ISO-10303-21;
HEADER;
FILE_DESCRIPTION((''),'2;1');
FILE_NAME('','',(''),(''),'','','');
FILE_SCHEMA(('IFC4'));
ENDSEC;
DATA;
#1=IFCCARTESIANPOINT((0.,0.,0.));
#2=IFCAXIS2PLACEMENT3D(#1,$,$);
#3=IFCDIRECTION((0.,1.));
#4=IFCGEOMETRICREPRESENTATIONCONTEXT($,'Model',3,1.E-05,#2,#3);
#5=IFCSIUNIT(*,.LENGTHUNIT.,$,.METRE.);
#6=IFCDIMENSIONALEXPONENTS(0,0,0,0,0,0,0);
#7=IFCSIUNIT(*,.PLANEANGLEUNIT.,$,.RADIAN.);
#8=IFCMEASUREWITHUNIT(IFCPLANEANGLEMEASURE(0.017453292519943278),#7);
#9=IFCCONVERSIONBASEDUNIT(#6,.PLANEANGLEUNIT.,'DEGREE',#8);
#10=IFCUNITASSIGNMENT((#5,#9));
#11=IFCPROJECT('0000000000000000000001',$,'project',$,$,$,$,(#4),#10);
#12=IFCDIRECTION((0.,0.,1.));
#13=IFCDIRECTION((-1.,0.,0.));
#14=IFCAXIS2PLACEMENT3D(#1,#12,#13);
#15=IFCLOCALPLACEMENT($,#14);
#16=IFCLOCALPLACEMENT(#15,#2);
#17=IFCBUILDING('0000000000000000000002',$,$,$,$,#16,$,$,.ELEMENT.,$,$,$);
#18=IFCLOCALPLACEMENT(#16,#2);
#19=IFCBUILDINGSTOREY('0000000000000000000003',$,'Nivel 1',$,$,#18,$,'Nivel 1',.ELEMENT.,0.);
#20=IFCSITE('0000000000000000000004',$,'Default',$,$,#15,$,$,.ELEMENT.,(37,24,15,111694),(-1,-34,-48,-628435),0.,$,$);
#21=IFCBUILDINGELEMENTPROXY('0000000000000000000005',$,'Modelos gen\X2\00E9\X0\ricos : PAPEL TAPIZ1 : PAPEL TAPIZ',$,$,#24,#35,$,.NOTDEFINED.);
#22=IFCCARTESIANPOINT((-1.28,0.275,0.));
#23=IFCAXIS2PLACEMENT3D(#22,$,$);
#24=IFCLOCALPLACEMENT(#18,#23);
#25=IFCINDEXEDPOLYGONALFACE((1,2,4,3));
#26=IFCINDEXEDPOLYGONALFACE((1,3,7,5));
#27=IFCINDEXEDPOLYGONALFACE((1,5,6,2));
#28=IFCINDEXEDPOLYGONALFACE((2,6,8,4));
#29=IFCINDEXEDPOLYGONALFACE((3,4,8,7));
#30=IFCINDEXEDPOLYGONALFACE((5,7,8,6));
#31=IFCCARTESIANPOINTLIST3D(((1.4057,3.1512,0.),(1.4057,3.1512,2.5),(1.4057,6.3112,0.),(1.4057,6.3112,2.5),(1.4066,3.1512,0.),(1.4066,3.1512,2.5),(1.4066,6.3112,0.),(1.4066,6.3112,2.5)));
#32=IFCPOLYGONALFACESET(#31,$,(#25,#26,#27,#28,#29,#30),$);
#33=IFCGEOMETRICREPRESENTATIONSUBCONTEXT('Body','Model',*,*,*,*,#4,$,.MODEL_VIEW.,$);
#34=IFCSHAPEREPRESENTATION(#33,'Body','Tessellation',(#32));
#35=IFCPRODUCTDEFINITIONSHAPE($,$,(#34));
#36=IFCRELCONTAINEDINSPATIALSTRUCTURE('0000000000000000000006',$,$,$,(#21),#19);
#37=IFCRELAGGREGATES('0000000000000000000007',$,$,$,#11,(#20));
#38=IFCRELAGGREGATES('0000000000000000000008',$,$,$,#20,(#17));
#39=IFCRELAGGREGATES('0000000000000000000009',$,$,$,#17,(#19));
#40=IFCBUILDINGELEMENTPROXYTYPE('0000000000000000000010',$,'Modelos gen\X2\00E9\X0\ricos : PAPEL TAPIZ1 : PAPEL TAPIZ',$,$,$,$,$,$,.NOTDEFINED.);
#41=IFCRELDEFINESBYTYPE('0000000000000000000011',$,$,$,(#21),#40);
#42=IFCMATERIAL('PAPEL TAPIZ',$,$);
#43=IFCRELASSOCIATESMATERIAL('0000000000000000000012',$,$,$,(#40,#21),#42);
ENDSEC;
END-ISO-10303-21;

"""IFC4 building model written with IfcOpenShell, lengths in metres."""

from ifc_helpers import new_model, entity, si_unit, converted_unit, direction, frame, origin, place, context, subcontext, project, spatial, indexed_curve, outline, extrude, source, transform, mapped, material, type_object, type_shapes, element, save


model = new_model("IFC4")

# Units and contexts
model_context = context("Model", 3, precision=1e-05, world=origin(), true_north=direction((0.0, 1.0)))
body_context = subcontext(model_context, "Body", "Model", "MODEL_VIEW")
ifc_project = project(units=[si_unit("LENGTHUNIT", "METRE"), converted_unit("PLANEANGLEUNIT", "DEGREE", entity("IfcPlaneAngleMeasure", 0.017453292519943278), si_unit("PLANEANGLEUNIT", "RADIAN"), dimensions=[0, 0, 0, 0, 0, 0, 0])], contexts=[model_context])

# Site, building, storey
site_placement = place(None, frame((0.0, 0.0, 0.0), z_axis=(0.0, 0.0, 1.0), x_axis=(-1.0, 0.0, 0.0)))
site = spatial("IfcSite", under=ifc_project, at=site_placement, Name="Default", CompositionType="ELEMENT", RefLatitude=(37, 24, 15, 111694), RefLongitude=(-1, -34, -48, -628435), RefElevation=0.0)
building_placement = place(site_placement, origin())
building = spatial("IfcBuilding", under=site, at=building_placement, CompositionType="ELEMENT")
storey_placement = place(building_placement, origin())
storey = spatial("IfcBuildingStorey", under=building, at=storey_placement, Name="Nivel 1", LongName="Nivel 1", CompositionType="ELEMENT", Elevation=0.0)

# Building element proxy
ifc_material_1 = material(Name="PAPEL TAPIZ")
building_element_proxy_type_1 = type_object("IfcBuildingElementProxyType", Name="Modelos genéricos : PAPEL TAPIZ1 : PAPEL TAPIZ", PredefinedType="NOTDEFINED", material=ifc_material_1)
shared_shape_1 = source(origin(), body_context, "Body", "SweptSolid", [
    extrude(outline(indexed_curve([(-0.0005, -1.58), (0.0005, -1.58), (0.0005, 1.58), (-0.0005, 1.58), (-0.0005, -1.58)], self_intersect=False)), frame((1.4062, 4.7312, 0.0)), (0.0, 0.0, 1.0), 2.5),
])
type_shapes(building_element_proxy_type_1, [shared_shape_1])
proxy_1_placement = place(storey_placement, frame((-1.28, 0.275, 0.0)))
element("IfcBuildingElementProxy", 1, at=proxy_1_placement, inside=storey, type_object=building_element_proxy_type_1, material=ifc_material_1, Name="Modelos genéricos : PAPEL TAPIZ1 : PAPEL TAPIZ", PredefinedType="NOTDEFINED", context=body_context, shape_type="MappedRepresentation", body=[
    mapped(shared_shape_1, transform((0.0, 0.0, 0.0), scale=1.0)),
])

save(model, "model.ifc")
